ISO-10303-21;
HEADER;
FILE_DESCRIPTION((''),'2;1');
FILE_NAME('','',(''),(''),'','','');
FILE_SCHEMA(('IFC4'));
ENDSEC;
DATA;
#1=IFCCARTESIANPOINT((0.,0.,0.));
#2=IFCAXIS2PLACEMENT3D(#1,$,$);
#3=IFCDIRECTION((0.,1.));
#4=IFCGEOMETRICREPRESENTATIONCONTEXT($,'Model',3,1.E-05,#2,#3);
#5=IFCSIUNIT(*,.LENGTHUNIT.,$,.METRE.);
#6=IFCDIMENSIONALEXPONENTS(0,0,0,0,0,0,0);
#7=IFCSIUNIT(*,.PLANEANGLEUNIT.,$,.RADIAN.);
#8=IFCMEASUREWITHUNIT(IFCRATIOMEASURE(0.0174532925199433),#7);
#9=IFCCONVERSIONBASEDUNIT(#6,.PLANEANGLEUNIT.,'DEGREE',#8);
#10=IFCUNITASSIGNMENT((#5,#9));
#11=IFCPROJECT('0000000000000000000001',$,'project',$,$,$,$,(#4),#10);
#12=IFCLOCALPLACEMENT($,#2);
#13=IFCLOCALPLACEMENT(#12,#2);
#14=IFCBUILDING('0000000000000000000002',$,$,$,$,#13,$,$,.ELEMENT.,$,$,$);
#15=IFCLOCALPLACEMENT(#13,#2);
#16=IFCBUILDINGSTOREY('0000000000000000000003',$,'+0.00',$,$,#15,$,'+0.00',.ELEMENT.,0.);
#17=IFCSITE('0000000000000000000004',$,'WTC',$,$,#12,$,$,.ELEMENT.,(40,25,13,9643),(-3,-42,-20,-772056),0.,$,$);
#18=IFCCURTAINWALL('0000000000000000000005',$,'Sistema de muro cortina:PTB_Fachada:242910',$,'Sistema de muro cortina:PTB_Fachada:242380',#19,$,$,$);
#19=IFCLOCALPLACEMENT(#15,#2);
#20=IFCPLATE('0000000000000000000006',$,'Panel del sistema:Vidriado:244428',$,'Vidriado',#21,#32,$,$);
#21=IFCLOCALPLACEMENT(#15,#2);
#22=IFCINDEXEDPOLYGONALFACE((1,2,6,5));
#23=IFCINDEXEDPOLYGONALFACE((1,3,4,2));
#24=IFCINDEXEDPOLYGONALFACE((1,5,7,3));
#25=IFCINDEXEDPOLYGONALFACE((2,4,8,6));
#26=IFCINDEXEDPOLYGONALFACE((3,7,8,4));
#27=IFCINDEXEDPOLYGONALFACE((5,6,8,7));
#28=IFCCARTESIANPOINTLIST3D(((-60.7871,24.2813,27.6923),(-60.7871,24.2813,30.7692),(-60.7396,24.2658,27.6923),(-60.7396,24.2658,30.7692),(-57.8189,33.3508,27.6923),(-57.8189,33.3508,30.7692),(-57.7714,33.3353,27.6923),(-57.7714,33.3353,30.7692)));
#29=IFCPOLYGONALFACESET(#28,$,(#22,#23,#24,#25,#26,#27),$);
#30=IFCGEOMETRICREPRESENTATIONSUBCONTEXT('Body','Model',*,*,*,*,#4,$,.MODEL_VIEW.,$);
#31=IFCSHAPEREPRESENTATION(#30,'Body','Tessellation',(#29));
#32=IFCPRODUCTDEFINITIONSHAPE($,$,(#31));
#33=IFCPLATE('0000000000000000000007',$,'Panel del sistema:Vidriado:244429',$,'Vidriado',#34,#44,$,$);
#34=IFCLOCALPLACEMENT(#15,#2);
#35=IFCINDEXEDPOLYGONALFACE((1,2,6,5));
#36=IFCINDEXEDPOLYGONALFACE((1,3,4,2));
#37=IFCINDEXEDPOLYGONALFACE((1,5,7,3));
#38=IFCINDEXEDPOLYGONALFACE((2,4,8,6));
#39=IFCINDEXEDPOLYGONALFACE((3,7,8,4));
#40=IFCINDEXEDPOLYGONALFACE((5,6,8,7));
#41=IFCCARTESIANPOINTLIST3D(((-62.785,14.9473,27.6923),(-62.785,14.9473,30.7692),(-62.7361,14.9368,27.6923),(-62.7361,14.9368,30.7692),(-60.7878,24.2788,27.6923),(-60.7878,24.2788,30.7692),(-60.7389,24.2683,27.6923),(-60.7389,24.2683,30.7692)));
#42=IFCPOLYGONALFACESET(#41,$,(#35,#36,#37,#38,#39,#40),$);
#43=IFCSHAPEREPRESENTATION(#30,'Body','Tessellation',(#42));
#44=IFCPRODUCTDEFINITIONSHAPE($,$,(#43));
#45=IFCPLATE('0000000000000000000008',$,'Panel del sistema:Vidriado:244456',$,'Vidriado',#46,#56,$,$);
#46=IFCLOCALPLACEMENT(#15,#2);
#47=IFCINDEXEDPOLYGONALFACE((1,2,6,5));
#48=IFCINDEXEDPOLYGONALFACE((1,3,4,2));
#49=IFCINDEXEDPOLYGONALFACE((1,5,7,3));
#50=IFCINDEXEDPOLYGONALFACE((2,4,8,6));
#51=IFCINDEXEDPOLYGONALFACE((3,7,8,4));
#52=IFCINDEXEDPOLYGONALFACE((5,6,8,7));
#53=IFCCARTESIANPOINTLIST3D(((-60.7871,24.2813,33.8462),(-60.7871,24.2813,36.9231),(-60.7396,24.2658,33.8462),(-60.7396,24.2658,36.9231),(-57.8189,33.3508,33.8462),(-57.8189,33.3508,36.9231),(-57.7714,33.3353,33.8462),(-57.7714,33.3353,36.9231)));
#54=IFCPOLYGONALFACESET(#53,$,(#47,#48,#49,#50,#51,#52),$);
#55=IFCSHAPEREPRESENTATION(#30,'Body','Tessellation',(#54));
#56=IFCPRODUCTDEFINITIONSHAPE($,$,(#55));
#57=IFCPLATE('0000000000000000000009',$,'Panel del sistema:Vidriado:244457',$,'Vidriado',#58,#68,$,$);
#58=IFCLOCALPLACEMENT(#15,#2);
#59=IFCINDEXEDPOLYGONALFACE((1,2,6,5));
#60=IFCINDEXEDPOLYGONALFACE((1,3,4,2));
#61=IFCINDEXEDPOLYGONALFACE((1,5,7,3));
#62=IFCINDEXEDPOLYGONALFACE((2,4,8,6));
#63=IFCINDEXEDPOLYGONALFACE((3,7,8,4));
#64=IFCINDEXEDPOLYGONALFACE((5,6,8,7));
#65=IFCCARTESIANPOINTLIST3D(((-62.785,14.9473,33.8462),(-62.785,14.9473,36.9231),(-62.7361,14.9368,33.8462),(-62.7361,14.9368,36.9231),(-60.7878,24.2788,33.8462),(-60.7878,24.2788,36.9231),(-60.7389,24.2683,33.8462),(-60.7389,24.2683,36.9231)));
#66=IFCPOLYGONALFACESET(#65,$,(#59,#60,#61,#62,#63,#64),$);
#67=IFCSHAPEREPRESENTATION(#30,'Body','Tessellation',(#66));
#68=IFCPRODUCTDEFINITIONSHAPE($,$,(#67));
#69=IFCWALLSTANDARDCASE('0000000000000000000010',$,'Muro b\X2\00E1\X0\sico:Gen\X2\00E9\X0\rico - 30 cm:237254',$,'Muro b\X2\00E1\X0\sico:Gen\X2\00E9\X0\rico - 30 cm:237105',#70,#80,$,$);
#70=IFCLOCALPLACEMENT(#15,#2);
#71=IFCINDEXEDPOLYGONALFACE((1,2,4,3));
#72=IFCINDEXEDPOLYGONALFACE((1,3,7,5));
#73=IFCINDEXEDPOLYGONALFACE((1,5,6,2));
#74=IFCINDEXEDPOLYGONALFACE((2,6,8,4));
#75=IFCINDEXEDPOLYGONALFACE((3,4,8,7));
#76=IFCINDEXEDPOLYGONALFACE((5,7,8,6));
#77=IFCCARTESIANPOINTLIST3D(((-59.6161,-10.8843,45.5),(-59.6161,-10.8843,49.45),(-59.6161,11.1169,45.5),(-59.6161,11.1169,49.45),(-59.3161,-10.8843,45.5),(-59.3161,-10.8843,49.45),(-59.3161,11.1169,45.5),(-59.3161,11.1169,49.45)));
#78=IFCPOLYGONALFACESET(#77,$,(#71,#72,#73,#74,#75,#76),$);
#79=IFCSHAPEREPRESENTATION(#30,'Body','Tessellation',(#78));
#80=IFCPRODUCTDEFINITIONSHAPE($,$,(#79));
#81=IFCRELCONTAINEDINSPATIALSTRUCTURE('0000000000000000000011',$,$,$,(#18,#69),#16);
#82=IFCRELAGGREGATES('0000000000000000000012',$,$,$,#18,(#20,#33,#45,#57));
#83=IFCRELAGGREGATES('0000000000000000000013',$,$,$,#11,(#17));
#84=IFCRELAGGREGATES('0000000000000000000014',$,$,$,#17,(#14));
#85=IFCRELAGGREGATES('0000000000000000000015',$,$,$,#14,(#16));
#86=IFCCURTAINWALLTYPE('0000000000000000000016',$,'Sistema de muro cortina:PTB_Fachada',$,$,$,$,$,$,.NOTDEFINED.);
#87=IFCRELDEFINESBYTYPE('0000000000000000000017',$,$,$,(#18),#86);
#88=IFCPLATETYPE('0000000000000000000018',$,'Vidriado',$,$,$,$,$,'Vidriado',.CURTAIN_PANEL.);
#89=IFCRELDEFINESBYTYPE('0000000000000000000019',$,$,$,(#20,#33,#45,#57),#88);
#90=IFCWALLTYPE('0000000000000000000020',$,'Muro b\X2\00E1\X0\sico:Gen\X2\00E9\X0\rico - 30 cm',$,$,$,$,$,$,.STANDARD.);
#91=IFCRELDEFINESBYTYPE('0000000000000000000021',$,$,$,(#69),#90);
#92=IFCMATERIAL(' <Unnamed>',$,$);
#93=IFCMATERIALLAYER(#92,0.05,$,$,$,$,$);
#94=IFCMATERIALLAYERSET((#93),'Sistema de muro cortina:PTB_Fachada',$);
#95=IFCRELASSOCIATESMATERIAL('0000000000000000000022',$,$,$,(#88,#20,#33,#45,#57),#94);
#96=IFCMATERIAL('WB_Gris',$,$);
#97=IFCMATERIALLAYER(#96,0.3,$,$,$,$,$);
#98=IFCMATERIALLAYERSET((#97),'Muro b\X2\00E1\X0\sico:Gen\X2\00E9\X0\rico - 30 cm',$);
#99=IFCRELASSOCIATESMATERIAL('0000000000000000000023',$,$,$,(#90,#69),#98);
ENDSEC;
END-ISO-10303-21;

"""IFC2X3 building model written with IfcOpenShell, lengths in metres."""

from ifc_helpers import new_model, entity, si_unit, converted_unit, direction, frame, frame_2d, origin, origin_2d_with_axis, place, context, subcontext, project, spatial, polyline, rectangle, extrude, clip, bounded_halfspace, source, transform, mapped, material, layer, layer_set, layer_usage, type_object, type_shapes, element, aggregate, save


model = new_model("IFC2X3")

# Units and contexts
model_context = context("Model", 3, precision=1e-05, world=origin(), true_north=direction((0.0, 1.0)))
body_context = subcontext(model_context, "Body", "Model", "MODEL_VIEW")
ifc_project = project(units=[si_unit("LENGTHUNIT", "METRE"), converted_unit("PLANEANGLEUNIT", "DEGREE", entity("IfcRatioMeasure", 0.0174532925199433), si_unit("PLANEANGLEUNIT", "RADIAN"), dimensions=[0, 0, 0, 0, 0, 0, 0])], contexts=[model_context])

# Site, building, storey
site_placement = place(None, origin())
site = spatial("IfcSite", under=ifc_project, at=site_placement, Name="WTC", CompositionType="ELEMENT", RefLatitude=(40, 25, 13, 9643), RefLongitude=(-3, -42, -20, -772056), RefElevation=0.0)
building_placement = place(site_placement, origin())
building = spatial("IfcBuilding", under=site, at=building_placement, CompositionType="ELEMENT")
storey_placement = place(building_placement, origin())
storey = spatial("IfcBuildingStorey", under=building, at=storey_placement, Name="+0.00", LongName="+0.00", CompositionType="ELEMENT", Elevation=0.0)

# Curtain wall, plates
curtain_wall_type = type_object("IfcCurtainWallType", Name="Sistema de muro cortina:PTB_Fachada", PredefinedType="NOTDEFINED")
curtain_wall_placement = place(storey_placement, origin())
curtain_wall = element("IfcCurtainWall", 1, at=curtain_wall_placement, inside=storey, type_object=curtain_wall_type, Name="Sistema de muro cortina:PTB_Fachada:242910", ObjectType="Sistema de muro cortina:PTB_Fachada:242380")
ifc_material_1 = material(Name=" <Unnamed>")
ifc_layer_1 = layer(ifc_material_1, 0.05)
ifc_layer_set_1 = layer_set([ifc_layer_1], Name="Sistema de muro cortina:PTB_Fachada")
plate_type_1 = type_object("IfcPlateType", Name="Vidriado", ElementType="Vidriado", PredefinedType="CURTAIN_PANEL", material=ifc_layer_set_1)
shared_shape_1 = source(origin(), body_context, "Body", "SweptSolid", [
    extrude(rectangle(XDim=0.05, YDim=9.5428, at=origin_2d_with_axis()), frame((0.0, 0.0, 0.0), z_axis=(0.0, 0.0, 1.0), x_axis=(0.0, 1.0, 0.0)), (0.0, 0.0, 1.0), 3.0769),
])
type_shapes(plate_type_1, [shared_shape_1])
ifc_layer_usage_1 = layer_usage(ifc_layer_set_1, "AXIS3", "POSITIVE", 0.0)
plate_1_placement = place(curtain_wall_placement, frame((-59.2792, 28.8083, 27.6923), z_axis=(0.0, 0.0, 1.0), x_axis=(-0.311036, -0.950398, 0.0)))
plate_1 = element("IfcPlate", 2, at=plate_1_placement, type_object=plate_type_1, material=ifc_layer_usage_1, Name="Panel del sistema:Vidriado:244428", ObjectType="Vidriado", context=body_context, shape_type="MappedRepresentation", body=[
    mapped(shared_shape_1, transform((0.0, 0.0, 0.0), scale=1.0)),
])
ifc_layer_usage_2 = layer_usage(ifc_layer_set_1, "AXIS3", "POSITIVE", 0.0)
plate_2_placement = place(curtain_wall_placement, frame((-61.762, 19.6078, 27.6923), z_axis=(0.0, 0.0, 1.0), x_axis=(-0.209296, -0.977852, 0.0)))
plate_2 = element("IfcPlate", 3, at=plate_2_placement, type_object=plate_type_1, material=ifc_layer_usage_2, Name="Panel del sistema:Vidriado:244429", ObjectType="Vidriado", context=body_context, shape_type="MappedRepresentation", body=[
    mapped(shared_shape_1, transform((0.0, 0.0, 0.0), scale=1.0)),
])
ifc_layer_usage_3 = layer_usage(ifc_layer_set_1, "AXIS3", "POSITIVE", 0.0)
plate_3_placement = place(curtain_wall_placement, frame((-59.2792, 28.8083, 33.8462), z_axis=(0.0, 0.0, 1.0), x_axis=(-0.311036, -0.950398, 0.0)))
plate_3 = element("IfcPlate", 4, at=plate_3_placement, type_object=plate_type_1, material=ifc_layer_usage_3, Name="Panel del sistema:Vidriado:244456", ObjectType="Vidriado", context=body_context, shape_type="MappedRepresentation", body=[
    mapped(shared_shape_1, transform((0.0, 0.0, 0.0), scale=1.0)),
])
ifc_layer_usage_4 = layer_usage(ifc_layer_set_1, "AXIS3", "POSITIVE", 0.0)
plate_4_placement = place(curtain_wall_placement, frame((-61.762, 19.6078, 33.8462), z_axis=(0.0, 0.0, 1.0), x_axis=(-0.209296, -0.977852, 0.0)))
plate_4 = element("IfcPlate", 5, at=plate_4_placement, type_object=plate_type_1, material=ifc_layer_usage_4, Name="Panel del sistema:Vidriado:244457", ObjectType="Vidriado", context=body_context, shape_type="MappedRepresentation", body=[
    mapped(shared_shape_1, transform((0.0, 0.0, 0.0), scale=1.0)),
])
aggregate(curtain_wall, [plate_1, plate_2, plate_3, plate_4])

# Wall
ifc_material_2 = material(Name="WB_Gris")
ifc_layer_2 = layer(ifc_material_2, 0.3)
ifc_layer_set_2 = layer_set([ifc_layer_2], Name="Muro básico:Genérico - 30 cm")
wall_type = type_object("IfcWallType", Name="Muro básico:Genérico - 30 cm", PredefinedType="STANDARD", material=ifc_layer_set_2)
ifc_layer_usage_5 = layer_usage(ifc_layer_set_2, "AXIS2", "NEGATIVE", 0.15)
wall_1_placement = place(storey_placement, frame((-59.4661, 11.1169, 45.5), z_axis=(0.0, 0.0, 1.0), x_axis=(0.0, -1.0, 0.0)))
element("IfcWallStandardCase", 6, at=wall_1_placement, inside=storey, type_object=wall_type, material=ifc_layer_usage_5, Name="Muro básico:Genérico - 30 cm:237254", ObjectType="Muro básico:Genérico - 30 cm:237105", context=body_context, shape_type="Clipping", body=[
    clip(extrude(rectangle(XDim=22.0012, YDim=0.3, at=frame_2d((11.0006, 0.0), x_axis=(-1.0, 0.0))), origin(), (0.0, 0.0, 1.0), 3.95), bounded_halfspace(frame((0.0, -0.15, 3.95), z_axis=(0.0, 0.0, 1.0), x_axis=(0.0, -1.0, 0.0)), False, frame((0.0, -0.15, 3.95), z_axis=(0.0, 0.0, 1.0), x_axis=(0.0, -1.0, 0.0)), polyline([(0.0, 0.0), (0.0, 22.0012), (-0.3, 22.0012), (-0.3, 21.7012), (-0.3, 0.3), (-0.3, 0.0), (0.0, 0.0)]))),
])

save(model, "model.ifc")
